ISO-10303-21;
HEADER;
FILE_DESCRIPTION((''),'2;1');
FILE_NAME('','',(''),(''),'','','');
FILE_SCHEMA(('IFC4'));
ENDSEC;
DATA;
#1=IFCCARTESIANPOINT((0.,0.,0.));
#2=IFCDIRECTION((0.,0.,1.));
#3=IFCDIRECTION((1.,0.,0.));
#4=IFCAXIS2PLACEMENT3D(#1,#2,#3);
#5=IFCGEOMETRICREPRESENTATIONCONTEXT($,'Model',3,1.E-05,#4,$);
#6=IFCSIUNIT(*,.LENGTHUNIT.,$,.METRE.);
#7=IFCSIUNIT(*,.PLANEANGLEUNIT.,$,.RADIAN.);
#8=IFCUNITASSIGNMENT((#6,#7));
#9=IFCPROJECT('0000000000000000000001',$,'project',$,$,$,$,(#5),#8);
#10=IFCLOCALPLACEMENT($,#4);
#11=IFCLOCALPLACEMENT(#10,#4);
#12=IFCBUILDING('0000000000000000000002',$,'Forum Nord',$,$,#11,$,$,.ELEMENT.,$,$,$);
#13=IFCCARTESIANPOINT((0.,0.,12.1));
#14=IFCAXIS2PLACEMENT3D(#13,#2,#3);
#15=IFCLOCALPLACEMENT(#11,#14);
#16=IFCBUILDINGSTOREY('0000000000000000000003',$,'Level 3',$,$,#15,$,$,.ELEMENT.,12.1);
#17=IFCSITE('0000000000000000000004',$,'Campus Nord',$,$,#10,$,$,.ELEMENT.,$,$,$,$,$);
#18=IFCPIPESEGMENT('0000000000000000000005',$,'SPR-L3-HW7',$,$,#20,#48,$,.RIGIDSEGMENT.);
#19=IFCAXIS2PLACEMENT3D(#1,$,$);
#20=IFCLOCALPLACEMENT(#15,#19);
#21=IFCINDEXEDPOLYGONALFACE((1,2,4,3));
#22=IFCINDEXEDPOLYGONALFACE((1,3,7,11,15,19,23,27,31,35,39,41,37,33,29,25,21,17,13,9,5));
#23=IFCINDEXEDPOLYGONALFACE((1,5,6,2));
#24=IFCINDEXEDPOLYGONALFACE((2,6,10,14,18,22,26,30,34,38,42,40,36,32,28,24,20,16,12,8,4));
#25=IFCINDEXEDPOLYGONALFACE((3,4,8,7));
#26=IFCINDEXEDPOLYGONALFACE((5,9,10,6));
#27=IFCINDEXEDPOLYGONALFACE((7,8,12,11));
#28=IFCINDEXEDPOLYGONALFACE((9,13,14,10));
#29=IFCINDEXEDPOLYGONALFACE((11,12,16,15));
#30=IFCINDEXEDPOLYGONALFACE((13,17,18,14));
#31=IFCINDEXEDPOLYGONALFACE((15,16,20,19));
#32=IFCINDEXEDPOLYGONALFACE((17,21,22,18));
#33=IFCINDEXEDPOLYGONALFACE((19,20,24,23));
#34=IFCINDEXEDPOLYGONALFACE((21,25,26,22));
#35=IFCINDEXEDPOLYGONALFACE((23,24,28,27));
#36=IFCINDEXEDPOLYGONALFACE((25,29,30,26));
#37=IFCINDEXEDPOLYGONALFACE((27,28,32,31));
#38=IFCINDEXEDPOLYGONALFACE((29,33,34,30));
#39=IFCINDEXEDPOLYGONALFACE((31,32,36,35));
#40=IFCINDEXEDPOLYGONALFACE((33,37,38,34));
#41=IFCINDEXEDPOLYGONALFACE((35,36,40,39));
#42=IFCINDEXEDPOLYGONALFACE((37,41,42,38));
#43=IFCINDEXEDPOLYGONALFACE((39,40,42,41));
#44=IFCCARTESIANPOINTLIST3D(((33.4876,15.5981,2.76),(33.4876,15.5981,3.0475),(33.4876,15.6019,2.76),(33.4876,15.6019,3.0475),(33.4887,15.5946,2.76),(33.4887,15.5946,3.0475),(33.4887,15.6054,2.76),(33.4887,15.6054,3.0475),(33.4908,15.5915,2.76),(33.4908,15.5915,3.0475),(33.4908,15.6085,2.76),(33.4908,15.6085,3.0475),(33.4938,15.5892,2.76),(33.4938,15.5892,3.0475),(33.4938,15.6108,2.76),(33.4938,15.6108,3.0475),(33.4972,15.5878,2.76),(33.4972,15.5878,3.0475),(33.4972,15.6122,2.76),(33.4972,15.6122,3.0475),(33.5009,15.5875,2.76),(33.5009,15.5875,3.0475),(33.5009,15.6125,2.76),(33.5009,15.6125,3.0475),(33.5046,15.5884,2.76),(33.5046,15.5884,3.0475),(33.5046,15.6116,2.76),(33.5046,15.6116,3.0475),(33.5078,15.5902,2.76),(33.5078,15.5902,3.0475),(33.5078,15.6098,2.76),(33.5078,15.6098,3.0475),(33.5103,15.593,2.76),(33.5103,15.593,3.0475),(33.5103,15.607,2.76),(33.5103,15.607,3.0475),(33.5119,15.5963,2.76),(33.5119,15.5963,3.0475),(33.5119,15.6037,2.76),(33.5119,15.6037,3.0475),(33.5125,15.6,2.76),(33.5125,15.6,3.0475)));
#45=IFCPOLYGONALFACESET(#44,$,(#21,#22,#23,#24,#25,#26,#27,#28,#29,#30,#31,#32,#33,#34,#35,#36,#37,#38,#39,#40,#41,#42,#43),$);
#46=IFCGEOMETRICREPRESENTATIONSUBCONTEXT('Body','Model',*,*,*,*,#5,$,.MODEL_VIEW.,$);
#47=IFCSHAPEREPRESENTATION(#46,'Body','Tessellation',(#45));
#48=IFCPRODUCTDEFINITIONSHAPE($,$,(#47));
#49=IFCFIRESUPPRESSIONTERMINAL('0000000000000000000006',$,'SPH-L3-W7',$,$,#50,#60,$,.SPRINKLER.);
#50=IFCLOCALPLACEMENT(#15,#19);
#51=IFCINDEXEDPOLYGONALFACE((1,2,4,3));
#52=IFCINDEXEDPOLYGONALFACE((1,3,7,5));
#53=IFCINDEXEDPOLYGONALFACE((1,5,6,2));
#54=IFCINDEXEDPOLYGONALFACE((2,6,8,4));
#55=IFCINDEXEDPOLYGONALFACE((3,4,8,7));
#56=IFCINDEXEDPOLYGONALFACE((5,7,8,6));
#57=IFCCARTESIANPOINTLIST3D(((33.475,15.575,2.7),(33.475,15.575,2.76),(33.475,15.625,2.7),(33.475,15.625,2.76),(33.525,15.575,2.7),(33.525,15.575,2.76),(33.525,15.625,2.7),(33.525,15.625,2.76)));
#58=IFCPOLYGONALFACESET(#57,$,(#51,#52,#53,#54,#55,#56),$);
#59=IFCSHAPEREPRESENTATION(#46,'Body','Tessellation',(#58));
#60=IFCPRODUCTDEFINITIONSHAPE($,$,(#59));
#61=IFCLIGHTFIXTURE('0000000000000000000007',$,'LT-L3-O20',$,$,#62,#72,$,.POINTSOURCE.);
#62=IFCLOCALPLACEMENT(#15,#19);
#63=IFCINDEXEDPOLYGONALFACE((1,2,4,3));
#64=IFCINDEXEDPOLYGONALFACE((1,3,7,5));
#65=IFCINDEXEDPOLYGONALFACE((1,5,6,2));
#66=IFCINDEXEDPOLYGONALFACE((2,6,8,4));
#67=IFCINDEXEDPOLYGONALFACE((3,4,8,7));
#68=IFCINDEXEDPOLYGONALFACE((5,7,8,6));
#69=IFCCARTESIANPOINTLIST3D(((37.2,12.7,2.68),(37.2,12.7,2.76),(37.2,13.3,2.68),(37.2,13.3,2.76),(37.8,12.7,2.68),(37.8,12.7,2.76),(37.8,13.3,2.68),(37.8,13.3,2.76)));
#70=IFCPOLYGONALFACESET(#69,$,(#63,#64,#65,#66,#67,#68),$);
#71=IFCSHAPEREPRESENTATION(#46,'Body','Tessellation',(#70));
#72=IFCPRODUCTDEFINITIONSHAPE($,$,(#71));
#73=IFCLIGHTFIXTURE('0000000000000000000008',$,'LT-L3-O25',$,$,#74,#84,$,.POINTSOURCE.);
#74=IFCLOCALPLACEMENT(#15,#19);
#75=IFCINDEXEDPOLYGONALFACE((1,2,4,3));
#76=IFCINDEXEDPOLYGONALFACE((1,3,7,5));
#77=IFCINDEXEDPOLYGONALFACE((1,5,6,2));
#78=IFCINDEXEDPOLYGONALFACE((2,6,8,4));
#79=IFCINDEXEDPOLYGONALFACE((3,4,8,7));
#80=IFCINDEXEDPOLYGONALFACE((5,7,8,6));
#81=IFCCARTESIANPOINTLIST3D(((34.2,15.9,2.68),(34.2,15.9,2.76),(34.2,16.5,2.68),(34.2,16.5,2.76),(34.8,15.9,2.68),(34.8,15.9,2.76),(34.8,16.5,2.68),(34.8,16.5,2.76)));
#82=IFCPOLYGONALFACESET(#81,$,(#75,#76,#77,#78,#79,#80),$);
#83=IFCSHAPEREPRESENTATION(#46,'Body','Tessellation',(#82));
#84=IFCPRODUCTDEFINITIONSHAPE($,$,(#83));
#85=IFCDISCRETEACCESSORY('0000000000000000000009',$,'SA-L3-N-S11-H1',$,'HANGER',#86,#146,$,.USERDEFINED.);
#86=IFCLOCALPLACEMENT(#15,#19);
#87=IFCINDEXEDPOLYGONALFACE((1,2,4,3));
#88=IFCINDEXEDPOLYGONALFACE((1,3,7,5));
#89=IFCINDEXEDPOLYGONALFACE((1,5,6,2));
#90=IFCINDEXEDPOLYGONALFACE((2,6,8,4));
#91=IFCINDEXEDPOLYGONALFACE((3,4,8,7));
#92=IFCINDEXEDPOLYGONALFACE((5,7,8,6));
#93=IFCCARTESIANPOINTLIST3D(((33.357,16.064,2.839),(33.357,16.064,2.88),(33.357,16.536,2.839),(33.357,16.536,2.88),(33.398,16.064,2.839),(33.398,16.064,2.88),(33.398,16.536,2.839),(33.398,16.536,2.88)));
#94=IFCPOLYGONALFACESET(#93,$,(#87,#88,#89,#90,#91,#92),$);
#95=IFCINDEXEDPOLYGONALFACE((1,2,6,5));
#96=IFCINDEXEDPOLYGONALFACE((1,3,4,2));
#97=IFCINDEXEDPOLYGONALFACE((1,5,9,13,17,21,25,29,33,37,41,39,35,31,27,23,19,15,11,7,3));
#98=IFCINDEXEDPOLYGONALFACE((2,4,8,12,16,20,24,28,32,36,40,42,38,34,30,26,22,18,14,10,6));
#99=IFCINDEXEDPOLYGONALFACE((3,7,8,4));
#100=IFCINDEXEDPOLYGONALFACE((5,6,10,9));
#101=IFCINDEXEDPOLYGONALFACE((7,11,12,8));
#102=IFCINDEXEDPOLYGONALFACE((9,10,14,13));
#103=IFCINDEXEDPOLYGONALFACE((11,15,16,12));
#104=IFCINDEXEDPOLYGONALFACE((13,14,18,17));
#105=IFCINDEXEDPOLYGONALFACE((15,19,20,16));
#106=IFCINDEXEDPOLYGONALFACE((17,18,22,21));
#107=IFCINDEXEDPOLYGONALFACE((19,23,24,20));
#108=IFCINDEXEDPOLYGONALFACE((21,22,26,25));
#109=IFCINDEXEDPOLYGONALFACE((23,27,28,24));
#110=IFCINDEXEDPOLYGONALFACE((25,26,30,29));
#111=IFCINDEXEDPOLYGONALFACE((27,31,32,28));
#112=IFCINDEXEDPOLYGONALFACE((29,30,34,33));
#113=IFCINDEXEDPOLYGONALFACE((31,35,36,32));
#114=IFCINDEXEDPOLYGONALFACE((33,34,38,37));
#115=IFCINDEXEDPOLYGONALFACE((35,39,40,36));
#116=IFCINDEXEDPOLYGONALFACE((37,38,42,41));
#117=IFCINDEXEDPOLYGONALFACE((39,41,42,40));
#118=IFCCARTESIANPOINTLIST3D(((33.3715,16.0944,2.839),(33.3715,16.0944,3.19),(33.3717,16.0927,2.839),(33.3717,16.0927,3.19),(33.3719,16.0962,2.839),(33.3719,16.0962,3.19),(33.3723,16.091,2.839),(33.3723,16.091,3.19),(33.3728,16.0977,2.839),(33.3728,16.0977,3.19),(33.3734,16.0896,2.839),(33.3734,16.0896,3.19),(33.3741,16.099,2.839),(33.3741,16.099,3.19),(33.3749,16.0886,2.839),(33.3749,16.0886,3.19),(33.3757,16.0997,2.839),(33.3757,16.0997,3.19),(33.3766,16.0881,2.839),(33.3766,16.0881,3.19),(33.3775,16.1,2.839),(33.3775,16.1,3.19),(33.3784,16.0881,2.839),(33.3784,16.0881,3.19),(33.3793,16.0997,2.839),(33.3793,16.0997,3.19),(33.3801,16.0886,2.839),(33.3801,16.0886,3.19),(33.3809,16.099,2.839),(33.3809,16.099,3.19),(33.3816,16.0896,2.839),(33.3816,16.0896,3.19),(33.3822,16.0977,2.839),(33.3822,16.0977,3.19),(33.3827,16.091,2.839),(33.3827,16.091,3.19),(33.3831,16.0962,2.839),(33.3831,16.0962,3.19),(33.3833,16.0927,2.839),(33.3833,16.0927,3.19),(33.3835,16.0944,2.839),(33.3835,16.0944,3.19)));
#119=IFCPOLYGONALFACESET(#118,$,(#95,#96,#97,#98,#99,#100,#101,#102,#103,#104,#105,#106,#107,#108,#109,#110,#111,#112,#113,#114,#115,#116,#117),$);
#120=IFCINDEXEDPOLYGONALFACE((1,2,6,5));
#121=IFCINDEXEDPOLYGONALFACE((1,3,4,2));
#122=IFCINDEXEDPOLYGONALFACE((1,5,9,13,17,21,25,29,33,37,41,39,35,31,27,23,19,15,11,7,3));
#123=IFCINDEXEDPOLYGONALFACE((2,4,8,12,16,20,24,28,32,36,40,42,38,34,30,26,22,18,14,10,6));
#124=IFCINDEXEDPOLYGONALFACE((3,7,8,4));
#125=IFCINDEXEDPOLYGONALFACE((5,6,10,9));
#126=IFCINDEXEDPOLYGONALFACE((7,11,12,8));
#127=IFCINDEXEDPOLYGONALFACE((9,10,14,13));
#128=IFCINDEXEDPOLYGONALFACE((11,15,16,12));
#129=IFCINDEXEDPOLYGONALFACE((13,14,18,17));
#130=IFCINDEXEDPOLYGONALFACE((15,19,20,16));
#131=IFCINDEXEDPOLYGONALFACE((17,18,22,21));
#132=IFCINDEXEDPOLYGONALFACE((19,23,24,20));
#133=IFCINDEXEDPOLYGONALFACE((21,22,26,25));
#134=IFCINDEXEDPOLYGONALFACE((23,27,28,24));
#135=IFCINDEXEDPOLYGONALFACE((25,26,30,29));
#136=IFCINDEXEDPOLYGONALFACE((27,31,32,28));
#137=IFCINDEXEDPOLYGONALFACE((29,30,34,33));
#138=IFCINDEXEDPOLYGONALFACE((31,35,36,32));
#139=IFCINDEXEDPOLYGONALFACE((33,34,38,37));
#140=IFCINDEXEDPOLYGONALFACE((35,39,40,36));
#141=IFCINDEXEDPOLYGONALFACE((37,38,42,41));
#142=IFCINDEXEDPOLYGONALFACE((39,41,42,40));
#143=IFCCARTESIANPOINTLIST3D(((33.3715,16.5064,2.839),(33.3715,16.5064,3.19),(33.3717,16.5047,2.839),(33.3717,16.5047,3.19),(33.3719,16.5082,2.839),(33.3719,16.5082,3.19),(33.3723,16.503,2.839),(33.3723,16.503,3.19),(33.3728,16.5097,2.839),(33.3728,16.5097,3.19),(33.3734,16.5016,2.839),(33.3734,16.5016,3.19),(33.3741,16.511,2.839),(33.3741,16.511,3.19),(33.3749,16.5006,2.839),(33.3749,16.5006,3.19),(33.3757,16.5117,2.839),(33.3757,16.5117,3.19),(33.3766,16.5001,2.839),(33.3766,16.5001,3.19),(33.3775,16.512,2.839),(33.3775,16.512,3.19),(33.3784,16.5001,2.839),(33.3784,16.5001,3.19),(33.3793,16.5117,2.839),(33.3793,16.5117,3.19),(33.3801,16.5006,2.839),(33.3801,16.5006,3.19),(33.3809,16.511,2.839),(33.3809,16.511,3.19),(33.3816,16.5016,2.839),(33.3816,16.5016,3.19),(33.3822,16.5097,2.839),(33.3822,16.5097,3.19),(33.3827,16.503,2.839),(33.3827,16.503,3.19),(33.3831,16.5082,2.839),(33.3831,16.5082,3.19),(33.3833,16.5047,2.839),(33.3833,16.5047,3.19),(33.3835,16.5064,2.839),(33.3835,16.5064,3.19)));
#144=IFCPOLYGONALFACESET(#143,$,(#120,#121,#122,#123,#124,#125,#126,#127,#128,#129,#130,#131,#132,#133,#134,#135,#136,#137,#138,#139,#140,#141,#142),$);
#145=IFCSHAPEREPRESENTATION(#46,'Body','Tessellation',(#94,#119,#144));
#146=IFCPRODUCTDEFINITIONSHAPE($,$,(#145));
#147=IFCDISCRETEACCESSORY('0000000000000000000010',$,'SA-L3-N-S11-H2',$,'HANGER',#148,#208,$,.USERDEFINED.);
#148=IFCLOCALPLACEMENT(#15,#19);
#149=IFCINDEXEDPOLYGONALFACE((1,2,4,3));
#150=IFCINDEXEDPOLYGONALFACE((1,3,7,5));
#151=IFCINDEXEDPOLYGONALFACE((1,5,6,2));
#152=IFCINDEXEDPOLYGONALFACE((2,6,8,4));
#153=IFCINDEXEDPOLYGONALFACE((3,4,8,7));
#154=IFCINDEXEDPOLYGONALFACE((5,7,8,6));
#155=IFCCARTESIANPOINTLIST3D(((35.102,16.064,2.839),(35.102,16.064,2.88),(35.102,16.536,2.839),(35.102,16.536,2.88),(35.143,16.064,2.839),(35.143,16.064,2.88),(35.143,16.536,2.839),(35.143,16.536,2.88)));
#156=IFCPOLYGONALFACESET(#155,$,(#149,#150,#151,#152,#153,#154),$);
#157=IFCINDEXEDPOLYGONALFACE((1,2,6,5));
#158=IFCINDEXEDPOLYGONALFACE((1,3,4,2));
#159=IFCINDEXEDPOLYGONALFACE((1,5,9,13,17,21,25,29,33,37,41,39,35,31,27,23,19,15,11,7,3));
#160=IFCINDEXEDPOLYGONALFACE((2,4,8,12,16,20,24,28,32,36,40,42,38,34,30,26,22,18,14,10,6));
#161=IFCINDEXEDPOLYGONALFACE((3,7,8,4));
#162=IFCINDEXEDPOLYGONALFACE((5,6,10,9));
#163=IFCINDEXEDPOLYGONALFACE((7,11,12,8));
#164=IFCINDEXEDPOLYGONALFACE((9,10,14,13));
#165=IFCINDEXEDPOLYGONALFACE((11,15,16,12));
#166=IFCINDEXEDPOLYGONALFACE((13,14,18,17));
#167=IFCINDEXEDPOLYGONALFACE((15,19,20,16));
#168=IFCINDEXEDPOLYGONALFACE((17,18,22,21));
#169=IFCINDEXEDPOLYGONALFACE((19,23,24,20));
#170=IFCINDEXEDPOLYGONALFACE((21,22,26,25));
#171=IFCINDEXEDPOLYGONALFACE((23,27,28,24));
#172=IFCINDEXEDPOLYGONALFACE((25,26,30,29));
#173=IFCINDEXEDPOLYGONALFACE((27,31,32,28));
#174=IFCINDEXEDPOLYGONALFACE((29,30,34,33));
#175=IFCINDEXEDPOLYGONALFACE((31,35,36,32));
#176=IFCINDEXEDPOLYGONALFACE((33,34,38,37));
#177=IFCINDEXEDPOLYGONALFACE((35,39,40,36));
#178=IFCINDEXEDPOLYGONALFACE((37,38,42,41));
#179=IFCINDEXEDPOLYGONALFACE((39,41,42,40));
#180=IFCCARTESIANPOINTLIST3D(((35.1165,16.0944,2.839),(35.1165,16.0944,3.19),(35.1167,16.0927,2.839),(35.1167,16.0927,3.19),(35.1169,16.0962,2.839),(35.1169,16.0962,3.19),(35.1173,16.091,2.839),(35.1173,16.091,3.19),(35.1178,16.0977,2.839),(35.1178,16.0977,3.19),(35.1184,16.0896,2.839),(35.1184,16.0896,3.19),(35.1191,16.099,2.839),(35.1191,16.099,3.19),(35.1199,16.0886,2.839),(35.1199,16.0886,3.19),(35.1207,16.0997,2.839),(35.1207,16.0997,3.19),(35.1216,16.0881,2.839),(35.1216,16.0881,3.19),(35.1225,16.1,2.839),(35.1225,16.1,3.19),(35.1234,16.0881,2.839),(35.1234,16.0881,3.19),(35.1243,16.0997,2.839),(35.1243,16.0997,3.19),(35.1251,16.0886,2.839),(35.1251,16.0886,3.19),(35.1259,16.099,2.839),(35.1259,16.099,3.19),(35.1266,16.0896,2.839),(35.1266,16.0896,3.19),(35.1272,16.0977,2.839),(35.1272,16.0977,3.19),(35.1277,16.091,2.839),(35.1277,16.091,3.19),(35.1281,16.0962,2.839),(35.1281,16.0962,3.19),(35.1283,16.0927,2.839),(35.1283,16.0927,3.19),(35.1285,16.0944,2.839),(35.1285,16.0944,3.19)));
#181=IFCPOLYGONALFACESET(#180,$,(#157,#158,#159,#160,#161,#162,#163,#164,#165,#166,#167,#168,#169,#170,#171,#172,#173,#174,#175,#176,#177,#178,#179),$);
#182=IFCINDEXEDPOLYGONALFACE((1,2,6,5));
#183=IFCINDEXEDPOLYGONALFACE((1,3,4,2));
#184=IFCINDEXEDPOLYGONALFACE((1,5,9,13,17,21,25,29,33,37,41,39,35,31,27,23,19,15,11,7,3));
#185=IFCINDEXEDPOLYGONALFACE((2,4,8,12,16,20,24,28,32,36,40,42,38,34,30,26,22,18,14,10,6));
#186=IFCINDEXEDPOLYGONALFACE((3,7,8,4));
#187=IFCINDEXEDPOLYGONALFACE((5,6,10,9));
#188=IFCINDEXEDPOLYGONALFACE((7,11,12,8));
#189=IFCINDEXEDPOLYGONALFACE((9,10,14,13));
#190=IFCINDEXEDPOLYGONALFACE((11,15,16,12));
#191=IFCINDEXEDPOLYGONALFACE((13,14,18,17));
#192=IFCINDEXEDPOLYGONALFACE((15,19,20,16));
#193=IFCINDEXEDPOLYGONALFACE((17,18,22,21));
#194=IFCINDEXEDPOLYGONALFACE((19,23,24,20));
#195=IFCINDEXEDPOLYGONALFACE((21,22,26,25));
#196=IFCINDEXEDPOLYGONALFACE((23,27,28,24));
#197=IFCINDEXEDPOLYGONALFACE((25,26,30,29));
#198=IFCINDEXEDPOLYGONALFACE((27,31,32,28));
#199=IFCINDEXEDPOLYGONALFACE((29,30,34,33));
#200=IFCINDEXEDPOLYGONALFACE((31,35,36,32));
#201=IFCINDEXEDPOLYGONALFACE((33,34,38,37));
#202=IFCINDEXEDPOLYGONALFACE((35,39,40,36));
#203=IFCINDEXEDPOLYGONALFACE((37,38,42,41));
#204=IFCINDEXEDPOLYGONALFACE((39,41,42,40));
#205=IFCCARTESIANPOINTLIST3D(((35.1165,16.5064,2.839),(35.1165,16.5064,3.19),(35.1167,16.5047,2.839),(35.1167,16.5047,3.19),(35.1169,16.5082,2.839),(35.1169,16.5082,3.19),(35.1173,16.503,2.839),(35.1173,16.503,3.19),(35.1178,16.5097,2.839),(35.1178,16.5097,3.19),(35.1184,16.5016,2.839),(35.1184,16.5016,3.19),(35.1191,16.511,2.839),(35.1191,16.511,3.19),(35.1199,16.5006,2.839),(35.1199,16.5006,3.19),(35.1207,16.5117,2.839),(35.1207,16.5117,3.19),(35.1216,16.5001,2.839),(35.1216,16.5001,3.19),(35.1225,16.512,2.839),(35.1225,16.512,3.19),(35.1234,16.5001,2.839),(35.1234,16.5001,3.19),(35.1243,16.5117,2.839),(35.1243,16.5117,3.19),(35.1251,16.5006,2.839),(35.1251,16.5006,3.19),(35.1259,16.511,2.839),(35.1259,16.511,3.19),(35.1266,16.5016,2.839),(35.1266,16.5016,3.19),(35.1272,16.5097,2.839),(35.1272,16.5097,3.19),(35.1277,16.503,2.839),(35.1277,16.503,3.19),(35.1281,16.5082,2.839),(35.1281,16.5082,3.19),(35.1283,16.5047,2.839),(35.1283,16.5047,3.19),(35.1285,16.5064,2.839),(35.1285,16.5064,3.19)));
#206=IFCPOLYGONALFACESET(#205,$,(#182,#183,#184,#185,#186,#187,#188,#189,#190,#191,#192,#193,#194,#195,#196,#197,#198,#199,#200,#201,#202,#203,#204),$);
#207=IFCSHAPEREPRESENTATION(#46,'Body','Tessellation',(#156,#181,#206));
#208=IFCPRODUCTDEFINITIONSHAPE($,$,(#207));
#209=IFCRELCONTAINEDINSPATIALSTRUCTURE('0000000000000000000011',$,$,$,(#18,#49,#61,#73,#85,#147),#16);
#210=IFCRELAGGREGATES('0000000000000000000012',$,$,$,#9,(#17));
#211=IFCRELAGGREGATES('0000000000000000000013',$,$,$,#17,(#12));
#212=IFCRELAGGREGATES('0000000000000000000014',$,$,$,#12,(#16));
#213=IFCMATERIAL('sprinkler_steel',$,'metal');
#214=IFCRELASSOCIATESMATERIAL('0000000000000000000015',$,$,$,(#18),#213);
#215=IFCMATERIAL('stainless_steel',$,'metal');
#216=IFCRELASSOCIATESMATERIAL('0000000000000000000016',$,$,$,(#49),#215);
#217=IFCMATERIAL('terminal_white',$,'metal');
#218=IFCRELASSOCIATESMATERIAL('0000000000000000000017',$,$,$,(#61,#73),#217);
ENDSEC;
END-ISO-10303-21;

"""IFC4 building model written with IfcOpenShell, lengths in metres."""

from ifc_helpers import new_model, si_unit, frame, frame_2d, origin_with_axes, origin_2d_with_axis, place, context, subcontext, project, spatial, rectangle, circle, extrude, material, element, save


model = new_model("IFC4")

# Units and contexts
model_context = context("Model", 3, precision=1e-05, world=origin_with_axes())
body_context = subcontext(model_context, "Body", "Model", "MODEL_VIEW")
ifc_project = project(units=[si_unit("LENGTHUNIT", "METRE"), si_unit("PLANEANGLEUNIT", "RADIAN")], contexts=[model_context])

# Site, building, storey
site_placement = place(None, origin_with_axes())
site = spatial("IfcSite", under=ifc_project, at=site_placement, Name="Campus Nord", CompositionType="ELEMENT")
building_placement = place(site_placement, origin_with_axes())
building = spatial("IfcBuilding", under=site, at=building_placement, Name="Forum Nord", CompositionType="ELEMENT")
storey_placement = place(building_placement, frame((0.0, 0.0, 12.1), z_axis=(0.0, 0.0, 1.0), x_axis=(1.0, 0.0, 0.0)))
storey = spatial("IfcBuildingStorey", under=building, at=storey_placement, Name="Level 3", CompositionType="ELEMENT", Elevation=12.1)

# Shared definitions
ifc_material_1 = material(Name="sprinkler_steel", Category="metal")

# Pipe segment
pipe_segment_1_placement = place(storey_placement, frame((33.5, 15.6, 3.0475), z_axis=(0.0, 0.0, -1.0), x_axis=(1.0, 0.0, 0.0)))
element("IfcPipeSegment", 1, at=pipe_segment_1_placement, inside=storey, material=ifc_material_1, Name="SPR-L3-HW7", PredefinedType="RIGIDSEGMENT", context=body_context, shape_type="SweptSolid", body=[
    extrude(circle(Radius=0.0125, at=origin_2d_with_axis()), origin_with_axes(), (0.0, 0.0, 1.0), 0.2875),
])

# Fire suppression terminal
ifc_material_2 = material(Name="stainless_steel", Category="metal")
fire_suppression_terminal_placement = place(storey_placement, frame((33.5, 15.6, 2.7), z_axis=(0.0, 0.0, 1.0), x_axis=(1.0, 0.0, 0.0)))
element("IfcFireSuppressionTerminal", 2, at=fire_suppression_terminal_placement, inside=storey, material=ifc_material_2, Name="SPH-L3-W7", PredefinedType="SPRINKLER", context=body_context, shape_type="SweptSolid", body=[
    extrude(rectangle(XDim=0.05, YDim=0.05, at=origin_2d_with_axis()), origin_with_axes(), (0.0, 0.0, 1.0), 0.06),
])

# Light fixtures
ifc_material_3 = material(Name="terminal_white", Category="metal")
for number, where, z_axis, x_axis, name in (
    (3, (37.5, 13.0, 2.68), (0.0, 0.0, 1.0), (1.0, 0.0, 0.0), "LT-L3-O20"),
    (4, (34.5, 16.2, 2.68), (0.0, 0.0, 1.0), (1.0, 0.0, 0.0), "LT-L3-O25"),
):
    element("IfcLightFixture", number, at=place(storey_placement, frame(where, z_axis=z_axis, x_axis=x_axis)), inside=storey, material=ifc_material_3, Name=name, PredefinedType="POINTSOURCE", context=body_context, shape_type="SweptSolid", body=[
        extrude(rectangle(XDim=0.6, YDim=0.6, at=origin_2d_with_axis()), origin_with_axes(), (0.0, 0.0, 1.0), 0.08),
    ])

# Discrete accessories
for number, where, z_axis, x_axis, name in (
    (5, (33.3775, 16.3, 2.88), (0.0, 0.0, 1.0), (0.0, 1.0, 0.0), "SA-L3-N-S11-H1"),
    (6, (35.1225, 16.3, 2.88), (0.0, 0.0, 1.0), (0.0, 1.0, 0.0), "SA-L3-N-S11-H2"),
):
    element("IfcDiscreteAccessory", number, at=place(storey_placement, frame(where, z_axis=z_axis, x_axis=x_axis)), inside=storey, Name=name, ObjectType="HANGER", PredefinedType="USERDEFINED", context=body_context, shape_type="SweptSolid", body=[
        extrude(rectangle(XDim=0.472, YDim=0.041, at=origin_2d_with_axis()), frame((0.0, 0.0, -0.041), z_axis=(0.0, 0.0, 1.0), x_axis=(1.0, 0.0, 0.0)), (0.0, 0.0, 1.0), 0.041),
        extrude(circle(Radius=0.006, at=frame_2d((-0.206, 0.0), x_axis=(1.0, 0.0))), frame((0.0, 0.0, -0.041), z_axis=(0.0, 0.0, 1.0), x_axis=(1.0, 0.0, 0.0)), (0.0, 0.0, 1.0), 0.351),
        extrude(circle(Radius=0.006, at=frame_2d((0.206, 0.0), x_axis=(1.0, 0.0))), frame((0.0, 0.0, -0.041), z_axis=(0.0, 0.0, 1.0), x_axis=(1.0, 0.0, 0.0)), (0.0, 0.0, 1.0), 0.351),
    ])

save(model, "model.ifc")
